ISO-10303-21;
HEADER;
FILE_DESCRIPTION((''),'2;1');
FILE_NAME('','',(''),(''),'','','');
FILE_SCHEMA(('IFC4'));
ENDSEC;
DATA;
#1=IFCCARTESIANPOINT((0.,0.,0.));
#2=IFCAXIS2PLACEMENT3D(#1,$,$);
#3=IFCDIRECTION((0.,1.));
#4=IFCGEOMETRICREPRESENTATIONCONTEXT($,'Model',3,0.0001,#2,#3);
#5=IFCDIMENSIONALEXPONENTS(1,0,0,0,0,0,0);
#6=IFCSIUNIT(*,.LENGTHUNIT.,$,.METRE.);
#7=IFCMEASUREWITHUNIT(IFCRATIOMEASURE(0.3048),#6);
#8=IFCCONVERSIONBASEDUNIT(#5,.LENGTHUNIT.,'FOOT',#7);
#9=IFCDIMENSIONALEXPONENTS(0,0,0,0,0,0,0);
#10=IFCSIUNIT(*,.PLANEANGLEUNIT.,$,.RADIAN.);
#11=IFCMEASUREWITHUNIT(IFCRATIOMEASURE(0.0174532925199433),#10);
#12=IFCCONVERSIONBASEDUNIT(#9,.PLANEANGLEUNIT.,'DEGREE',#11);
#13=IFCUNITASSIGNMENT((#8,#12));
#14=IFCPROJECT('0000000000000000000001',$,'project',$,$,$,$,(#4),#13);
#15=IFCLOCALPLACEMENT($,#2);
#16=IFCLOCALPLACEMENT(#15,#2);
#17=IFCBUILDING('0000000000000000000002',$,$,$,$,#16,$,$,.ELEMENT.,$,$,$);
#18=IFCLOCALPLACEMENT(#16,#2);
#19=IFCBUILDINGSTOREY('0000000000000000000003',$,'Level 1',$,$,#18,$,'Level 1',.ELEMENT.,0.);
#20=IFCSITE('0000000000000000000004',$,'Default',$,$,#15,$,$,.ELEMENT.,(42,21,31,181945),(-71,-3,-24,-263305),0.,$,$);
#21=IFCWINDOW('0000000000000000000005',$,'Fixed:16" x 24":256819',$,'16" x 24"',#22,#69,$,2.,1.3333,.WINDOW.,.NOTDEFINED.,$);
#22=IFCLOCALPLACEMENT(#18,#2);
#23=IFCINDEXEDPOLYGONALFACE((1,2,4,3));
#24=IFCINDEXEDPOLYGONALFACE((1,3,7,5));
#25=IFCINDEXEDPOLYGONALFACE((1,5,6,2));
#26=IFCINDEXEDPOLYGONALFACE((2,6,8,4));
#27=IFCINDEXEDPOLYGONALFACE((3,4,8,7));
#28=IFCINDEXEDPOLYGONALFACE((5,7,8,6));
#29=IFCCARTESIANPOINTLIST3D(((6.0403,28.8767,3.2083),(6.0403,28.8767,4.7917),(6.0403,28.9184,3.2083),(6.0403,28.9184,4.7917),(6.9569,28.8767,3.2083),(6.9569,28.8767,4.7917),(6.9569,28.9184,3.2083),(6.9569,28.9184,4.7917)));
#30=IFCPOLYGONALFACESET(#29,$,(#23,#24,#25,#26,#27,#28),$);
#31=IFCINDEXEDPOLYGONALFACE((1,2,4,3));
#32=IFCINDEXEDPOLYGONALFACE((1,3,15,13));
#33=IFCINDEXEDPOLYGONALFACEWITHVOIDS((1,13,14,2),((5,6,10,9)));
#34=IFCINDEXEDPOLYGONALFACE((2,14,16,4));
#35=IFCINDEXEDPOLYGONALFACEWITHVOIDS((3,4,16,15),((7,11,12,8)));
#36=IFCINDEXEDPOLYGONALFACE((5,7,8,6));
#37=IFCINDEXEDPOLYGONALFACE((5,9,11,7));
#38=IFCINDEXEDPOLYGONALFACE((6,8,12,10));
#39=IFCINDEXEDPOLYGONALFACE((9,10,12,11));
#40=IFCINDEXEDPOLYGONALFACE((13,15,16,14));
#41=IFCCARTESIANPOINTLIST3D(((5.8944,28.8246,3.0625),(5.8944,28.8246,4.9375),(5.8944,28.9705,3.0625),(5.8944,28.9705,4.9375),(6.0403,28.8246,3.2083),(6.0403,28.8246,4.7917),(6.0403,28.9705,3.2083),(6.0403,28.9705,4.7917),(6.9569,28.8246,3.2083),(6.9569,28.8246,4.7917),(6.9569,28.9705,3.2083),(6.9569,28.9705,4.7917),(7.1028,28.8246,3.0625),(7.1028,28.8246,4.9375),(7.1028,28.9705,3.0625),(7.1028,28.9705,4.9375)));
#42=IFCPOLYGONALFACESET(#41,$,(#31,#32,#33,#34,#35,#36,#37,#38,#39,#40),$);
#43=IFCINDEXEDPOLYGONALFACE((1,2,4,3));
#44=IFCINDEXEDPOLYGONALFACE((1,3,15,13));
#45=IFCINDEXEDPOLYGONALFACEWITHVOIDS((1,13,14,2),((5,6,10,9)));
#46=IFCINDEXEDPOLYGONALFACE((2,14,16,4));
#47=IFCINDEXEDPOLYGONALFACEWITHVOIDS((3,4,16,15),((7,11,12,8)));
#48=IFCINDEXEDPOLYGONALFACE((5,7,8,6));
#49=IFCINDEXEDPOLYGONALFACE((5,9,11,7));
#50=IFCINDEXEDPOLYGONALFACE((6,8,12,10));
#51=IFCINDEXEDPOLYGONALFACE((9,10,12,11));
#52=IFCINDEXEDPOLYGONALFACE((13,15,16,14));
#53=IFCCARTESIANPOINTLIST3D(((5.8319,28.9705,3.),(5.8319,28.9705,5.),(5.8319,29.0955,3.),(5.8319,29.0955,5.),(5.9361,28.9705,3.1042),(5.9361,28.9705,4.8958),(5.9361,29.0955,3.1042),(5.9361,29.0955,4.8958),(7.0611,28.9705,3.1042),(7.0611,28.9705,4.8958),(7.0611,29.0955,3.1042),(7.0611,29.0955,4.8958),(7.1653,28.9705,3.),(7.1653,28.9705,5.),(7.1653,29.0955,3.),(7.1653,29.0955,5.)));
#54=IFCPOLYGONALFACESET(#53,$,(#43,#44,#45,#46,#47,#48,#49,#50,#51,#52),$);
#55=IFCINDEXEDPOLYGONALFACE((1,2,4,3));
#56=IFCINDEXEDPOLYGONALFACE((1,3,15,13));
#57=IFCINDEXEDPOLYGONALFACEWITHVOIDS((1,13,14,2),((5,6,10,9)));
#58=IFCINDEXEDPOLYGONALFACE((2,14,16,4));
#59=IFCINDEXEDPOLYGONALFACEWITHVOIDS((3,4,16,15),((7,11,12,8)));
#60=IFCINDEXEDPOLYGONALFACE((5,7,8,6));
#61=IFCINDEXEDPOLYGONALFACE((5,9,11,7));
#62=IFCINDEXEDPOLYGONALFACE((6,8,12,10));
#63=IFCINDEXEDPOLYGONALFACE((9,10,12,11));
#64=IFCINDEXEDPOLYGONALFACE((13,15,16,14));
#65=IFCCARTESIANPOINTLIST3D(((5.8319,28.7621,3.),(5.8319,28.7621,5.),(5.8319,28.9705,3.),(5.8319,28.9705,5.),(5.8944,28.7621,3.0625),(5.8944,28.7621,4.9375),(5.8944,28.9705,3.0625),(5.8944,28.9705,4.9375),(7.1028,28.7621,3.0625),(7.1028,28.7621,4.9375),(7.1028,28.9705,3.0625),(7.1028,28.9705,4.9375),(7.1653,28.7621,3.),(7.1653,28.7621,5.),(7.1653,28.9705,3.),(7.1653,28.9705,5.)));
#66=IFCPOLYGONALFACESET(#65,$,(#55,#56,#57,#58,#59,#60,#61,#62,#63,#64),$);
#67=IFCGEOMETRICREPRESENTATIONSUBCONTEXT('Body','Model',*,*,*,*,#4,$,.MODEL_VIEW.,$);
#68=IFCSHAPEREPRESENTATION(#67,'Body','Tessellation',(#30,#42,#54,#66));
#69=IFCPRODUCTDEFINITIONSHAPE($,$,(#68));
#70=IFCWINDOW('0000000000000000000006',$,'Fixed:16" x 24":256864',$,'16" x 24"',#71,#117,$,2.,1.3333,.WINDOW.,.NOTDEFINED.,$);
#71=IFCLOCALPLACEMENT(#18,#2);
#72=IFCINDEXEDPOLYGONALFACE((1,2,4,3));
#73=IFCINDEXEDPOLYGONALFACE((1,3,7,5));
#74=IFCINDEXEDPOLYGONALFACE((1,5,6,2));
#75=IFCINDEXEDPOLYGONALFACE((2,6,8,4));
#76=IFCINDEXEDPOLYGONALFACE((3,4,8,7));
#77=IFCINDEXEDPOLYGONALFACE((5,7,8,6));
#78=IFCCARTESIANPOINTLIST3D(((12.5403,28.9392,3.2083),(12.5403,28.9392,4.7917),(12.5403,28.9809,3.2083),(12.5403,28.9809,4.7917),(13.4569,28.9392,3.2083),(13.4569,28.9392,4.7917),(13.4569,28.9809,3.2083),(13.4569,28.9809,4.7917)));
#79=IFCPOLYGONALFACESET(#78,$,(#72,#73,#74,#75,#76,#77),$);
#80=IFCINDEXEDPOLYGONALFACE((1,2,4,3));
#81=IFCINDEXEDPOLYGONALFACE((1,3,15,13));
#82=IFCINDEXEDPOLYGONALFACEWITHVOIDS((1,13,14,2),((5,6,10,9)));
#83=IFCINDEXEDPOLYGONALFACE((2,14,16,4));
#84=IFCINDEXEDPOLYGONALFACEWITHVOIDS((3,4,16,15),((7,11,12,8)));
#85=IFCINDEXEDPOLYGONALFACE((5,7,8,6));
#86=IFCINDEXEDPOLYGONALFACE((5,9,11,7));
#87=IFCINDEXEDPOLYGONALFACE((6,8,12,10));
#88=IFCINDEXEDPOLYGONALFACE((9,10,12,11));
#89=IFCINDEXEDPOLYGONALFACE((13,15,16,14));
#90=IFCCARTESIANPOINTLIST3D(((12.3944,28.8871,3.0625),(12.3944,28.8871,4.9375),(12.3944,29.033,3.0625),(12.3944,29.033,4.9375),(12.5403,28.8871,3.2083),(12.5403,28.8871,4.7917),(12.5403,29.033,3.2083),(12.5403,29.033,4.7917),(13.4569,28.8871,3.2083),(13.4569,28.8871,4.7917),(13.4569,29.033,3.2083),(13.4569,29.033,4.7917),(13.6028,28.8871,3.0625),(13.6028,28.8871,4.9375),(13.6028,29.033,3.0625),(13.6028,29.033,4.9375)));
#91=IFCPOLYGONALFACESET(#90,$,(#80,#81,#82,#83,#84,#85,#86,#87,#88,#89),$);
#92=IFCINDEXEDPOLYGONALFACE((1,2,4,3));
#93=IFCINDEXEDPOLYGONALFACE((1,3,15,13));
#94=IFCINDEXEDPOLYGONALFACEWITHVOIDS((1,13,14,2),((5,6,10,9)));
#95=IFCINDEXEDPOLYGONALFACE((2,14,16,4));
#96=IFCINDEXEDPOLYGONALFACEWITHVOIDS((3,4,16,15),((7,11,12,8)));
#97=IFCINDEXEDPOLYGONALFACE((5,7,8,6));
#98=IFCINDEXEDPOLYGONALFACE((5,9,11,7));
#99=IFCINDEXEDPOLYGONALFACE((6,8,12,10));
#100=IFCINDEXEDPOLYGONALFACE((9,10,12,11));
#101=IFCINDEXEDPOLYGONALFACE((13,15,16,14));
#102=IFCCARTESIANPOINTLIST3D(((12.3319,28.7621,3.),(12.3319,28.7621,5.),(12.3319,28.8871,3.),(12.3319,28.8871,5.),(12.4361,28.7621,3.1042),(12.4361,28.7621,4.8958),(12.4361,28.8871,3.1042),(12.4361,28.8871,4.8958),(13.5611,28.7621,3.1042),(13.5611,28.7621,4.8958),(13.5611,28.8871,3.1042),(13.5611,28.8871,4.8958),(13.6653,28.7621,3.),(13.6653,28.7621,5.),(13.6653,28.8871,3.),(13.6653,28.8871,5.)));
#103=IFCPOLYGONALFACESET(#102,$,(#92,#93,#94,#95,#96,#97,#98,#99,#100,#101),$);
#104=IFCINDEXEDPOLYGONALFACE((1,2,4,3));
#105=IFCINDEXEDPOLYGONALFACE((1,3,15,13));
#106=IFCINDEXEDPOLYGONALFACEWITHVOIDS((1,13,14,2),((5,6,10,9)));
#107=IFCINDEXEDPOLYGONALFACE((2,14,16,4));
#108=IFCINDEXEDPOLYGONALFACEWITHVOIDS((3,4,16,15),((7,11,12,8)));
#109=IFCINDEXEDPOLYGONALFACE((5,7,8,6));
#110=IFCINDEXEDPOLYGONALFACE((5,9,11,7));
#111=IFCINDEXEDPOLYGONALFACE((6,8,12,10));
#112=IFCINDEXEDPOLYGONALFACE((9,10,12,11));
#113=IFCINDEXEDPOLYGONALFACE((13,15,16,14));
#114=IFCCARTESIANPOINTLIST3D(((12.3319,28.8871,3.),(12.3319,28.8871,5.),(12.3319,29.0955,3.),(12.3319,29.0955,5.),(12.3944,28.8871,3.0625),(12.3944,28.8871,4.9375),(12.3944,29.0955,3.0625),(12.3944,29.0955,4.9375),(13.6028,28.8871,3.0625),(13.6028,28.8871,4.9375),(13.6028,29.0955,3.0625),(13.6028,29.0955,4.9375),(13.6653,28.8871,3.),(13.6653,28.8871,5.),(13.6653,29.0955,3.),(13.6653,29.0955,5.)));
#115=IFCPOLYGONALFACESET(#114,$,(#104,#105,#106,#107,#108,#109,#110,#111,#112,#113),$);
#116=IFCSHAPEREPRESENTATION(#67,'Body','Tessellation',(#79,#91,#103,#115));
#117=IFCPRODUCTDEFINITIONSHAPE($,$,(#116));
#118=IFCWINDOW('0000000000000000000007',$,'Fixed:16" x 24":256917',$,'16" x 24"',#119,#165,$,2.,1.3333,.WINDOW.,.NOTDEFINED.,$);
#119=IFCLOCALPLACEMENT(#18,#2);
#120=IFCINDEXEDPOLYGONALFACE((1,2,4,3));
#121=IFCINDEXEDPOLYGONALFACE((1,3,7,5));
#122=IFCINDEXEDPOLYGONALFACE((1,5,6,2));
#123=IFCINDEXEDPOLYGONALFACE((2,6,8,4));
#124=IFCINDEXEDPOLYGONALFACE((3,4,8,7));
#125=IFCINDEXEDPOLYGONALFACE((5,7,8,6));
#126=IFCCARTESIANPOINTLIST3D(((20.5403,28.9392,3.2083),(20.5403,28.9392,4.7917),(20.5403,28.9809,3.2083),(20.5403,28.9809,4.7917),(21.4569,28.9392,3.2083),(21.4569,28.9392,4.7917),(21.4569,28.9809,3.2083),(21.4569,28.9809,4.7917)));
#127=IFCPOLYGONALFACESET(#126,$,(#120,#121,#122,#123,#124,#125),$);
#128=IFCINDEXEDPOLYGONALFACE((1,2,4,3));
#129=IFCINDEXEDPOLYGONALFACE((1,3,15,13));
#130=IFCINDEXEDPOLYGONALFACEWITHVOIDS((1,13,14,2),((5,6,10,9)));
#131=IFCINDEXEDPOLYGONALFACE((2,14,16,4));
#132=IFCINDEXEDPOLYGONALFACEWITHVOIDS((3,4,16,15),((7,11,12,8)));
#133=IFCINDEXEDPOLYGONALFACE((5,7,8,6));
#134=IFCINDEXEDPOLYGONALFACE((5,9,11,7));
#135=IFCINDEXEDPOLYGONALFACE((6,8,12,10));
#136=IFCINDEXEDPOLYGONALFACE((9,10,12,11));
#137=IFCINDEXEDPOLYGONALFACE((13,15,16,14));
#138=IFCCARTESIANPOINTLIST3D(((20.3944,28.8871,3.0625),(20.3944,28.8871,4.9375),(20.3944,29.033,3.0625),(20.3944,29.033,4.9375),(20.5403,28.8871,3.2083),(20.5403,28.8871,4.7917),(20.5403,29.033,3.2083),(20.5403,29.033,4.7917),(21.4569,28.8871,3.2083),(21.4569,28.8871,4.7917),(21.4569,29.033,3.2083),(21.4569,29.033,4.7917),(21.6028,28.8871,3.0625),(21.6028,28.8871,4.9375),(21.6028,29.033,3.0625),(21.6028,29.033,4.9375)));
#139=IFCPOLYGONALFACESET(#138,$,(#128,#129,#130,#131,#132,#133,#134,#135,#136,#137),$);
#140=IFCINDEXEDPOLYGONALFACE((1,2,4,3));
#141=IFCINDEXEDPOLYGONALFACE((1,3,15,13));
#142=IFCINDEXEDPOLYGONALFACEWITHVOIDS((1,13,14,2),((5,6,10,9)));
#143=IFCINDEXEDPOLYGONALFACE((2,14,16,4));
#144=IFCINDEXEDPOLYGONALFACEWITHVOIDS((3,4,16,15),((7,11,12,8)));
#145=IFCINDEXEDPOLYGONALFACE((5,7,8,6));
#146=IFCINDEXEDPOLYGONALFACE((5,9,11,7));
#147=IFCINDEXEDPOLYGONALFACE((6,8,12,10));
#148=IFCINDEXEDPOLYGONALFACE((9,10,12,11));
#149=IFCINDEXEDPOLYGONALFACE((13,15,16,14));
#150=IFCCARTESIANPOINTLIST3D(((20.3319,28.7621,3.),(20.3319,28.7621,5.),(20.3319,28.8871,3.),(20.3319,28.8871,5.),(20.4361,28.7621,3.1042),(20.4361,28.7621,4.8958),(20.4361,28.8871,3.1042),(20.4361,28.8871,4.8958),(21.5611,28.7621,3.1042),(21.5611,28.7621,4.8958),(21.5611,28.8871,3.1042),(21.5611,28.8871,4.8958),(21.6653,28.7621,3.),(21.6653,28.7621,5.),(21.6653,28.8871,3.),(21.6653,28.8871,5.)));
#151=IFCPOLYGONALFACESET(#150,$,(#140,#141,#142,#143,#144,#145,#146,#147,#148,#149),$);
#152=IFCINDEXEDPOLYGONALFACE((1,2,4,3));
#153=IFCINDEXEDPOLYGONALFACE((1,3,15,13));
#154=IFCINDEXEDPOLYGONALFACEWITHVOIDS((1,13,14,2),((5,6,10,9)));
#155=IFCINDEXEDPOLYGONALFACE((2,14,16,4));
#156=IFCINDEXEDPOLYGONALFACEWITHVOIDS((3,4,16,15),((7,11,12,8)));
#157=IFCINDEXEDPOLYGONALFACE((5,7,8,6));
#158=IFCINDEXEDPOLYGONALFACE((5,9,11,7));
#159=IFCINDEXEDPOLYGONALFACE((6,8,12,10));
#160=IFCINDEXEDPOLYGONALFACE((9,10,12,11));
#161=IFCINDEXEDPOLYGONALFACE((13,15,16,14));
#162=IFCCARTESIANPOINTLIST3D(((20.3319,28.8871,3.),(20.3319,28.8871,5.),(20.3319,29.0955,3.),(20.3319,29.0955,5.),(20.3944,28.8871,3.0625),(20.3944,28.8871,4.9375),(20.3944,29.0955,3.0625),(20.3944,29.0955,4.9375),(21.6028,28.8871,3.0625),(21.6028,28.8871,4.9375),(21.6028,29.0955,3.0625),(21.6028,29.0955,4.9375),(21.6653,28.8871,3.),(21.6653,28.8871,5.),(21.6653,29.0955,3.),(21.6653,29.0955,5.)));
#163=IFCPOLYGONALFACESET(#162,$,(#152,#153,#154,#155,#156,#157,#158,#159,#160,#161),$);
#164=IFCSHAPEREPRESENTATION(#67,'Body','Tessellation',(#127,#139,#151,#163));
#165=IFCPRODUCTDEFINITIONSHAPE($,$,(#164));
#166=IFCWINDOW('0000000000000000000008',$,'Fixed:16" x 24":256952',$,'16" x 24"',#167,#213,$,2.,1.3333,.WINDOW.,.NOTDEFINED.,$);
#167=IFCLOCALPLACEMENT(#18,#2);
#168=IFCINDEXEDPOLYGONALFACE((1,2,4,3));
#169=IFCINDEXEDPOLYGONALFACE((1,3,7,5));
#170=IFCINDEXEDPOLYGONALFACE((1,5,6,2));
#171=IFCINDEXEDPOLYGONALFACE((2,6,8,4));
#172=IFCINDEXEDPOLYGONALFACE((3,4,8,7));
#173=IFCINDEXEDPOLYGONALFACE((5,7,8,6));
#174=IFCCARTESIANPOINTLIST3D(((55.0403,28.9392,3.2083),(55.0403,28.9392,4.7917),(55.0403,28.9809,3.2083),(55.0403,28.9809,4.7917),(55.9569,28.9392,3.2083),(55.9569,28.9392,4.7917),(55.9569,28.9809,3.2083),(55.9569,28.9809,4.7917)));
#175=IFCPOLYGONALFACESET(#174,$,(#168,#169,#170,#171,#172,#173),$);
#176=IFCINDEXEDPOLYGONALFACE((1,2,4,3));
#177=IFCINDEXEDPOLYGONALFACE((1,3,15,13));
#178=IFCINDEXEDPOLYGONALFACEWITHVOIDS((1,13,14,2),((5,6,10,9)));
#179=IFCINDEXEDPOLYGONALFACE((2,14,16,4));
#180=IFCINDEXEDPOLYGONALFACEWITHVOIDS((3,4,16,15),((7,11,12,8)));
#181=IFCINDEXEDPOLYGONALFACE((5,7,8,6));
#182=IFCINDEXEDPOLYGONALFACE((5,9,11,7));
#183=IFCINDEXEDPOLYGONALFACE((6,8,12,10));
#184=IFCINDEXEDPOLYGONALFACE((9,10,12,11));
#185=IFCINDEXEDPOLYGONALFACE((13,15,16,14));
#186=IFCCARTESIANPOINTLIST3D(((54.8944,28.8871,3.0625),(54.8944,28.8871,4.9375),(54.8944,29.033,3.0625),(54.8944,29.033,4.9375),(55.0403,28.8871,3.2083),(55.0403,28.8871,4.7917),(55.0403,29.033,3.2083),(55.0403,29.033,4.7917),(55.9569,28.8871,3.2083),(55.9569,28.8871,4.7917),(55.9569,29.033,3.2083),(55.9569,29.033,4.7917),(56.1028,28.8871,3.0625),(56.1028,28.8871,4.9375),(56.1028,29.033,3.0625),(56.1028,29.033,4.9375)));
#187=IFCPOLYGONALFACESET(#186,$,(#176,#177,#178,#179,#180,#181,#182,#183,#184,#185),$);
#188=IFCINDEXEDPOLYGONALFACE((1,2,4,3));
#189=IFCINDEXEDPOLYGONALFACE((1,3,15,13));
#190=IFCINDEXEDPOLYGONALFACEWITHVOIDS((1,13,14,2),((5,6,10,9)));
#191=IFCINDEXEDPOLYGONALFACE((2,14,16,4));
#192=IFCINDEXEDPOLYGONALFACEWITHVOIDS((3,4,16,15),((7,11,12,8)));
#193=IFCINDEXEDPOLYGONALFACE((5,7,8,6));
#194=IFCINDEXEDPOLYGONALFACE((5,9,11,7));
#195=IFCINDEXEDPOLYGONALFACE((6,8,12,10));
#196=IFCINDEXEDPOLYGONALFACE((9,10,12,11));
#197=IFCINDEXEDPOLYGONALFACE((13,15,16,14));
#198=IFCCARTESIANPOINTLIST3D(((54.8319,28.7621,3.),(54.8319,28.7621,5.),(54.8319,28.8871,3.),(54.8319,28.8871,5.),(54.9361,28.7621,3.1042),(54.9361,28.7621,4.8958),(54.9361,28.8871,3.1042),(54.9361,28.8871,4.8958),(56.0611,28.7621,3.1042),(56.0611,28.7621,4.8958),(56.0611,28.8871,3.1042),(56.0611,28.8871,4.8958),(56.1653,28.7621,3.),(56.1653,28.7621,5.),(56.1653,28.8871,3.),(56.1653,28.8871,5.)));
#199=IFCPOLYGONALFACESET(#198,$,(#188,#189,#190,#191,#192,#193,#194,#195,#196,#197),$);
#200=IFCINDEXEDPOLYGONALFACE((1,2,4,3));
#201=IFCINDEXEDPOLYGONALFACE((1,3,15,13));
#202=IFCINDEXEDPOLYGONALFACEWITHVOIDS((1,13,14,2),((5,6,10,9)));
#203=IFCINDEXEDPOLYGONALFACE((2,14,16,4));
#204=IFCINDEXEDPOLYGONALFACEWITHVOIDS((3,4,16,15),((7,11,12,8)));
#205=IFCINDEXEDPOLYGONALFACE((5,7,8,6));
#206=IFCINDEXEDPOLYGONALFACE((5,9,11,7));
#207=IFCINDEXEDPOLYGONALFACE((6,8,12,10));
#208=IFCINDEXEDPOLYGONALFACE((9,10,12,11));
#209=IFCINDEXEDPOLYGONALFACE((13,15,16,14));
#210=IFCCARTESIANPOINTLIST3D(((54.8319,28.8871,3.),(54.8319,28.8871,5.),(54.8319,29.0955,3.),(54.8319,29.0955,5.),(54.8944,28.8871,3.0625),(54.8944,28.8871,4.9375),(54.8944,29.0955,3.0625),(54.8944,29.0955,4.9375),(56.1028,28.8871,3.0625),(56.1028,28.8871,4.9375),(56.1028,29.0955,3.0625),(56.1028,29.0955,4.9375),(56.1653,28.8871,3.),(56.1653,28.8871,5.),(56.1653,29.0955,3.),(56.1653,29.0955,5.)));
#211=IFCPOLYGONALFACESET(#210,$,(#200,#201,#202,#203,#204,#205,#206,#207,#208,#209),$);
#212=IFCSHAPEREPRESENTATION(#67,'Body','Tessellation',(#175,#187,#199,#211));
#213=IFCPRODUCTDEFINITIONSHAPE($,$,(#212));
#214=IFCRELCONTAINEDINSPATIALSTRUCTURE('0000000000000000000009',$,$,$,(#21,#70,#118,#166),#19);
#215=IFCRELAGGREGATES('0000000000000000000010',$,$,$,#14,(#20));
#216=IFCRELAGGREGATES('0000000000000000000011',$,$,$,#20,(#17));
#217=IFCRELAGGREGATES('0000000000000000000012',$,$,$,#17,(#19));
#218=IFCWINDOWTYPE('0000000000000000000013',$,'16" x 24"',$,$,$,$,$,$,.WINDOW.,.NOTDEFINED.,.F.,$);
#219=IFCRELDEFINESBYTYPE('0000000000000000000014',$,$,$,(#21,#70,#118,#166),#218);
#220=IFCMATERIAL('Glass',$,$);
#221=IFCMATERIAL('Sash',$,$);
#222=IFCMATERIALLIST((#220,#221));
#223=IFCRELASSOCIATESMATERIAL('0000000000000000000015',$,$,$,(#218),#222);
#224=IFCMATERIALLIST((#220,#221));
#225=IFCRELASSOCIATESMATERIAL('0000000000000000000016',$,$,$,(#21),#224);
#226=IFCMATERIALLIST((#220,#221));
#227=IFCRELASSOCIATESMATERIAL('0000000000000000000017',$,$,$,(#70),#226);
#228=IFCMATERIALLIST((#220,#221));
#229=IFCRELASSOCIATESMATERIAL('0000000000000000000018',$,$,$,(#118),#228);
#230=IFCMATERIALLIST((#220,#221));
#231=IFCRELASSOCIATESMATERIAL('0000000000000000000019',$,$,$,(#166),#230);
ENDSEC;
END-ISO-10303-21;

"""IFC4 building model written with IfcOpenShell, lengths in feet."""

from ifc_helpers import new_model, entity, si_unit, converted_unit, direction, frame, origin, origin_2d_with_axis, place, context, subcontext, project, spatial, polyline, rectangle, outline, extrude, source, transform, mapped, material, material_list, type_object, type_shapes, element, save


model = new_model("IFC4")

# Units and contexts
model_context = context("Model", 3, precision=0.0001, world=origin(), true_north=direction((0.0, 1.0)))
body_context = subcontext(model_context, "Body", "Model", "MODEL_VIEW")
ifc_project = project(units=[converted_unit("LENGTHUNIT", "FOOT", entity("IfcRatioMeasure", 0.3048), si_unit("LENGTHUNIT", "METRE"), dimensions=[1, 0, 0, 0, 0, 0, 0]), converted_unit("PLANEANGLEUNIT", "DEGREE", entity("IfcRatioMeasure", 0.0174532925199433), si_unit("PLANEANGLEUNIT", "RADIAN"), dimensions=[0, 0, 0, 0, 0, 0, 0])], contexts=[model_context])

# Site, building, storey
site_placement = place(None, origin())
site = spatial("IfcSite", under=ifc_project, at=site_placement, Name="Default", CompositionType="ELEMENT", RefLatitude=(42, 21, 31, 181945), RefLongitude=(-71, -3, -24, -263305), RefElevation=0.0)
building_placement = place(site_placement, origin())
building = spatial("IfcBuilding", under=site, at=building_placement, CompositionType="ELEMENT")
storey_placement = place(building_placement, origin())
storey = spatial("IfcBuildingStorey", under=building, at=storey_placement, Name="Level 1", LongName="Level 1", CompositionType="ELEMENT", Elevation=0.0)

# Windows
ifc_material_1 = material(Name="Glass")
ifc_material_2 = material(Name="Sash")
ifc_material_list_1 = material_list([ifc_material_1, ifc_material_2])
ifc_material_list_2 = material_list([ifc_material_1, ifc_material_2])
window_type = type_object("IfcWindowType", Name="16\" x 24\"", ParameterTakesPrecedence=False, PartitioningType="NOTDEFINED", PredefinedType="WINDOW", material=ifc_material_list_2)
shared_shape_1 = source(origin(), body_context, "Body", "SweptSolid", [
    extrude(rectangle(XDim=0.0417, YDim=0.9167, at=origin_2d_with_axis()), frame((0.6667, 0.1979, 0.2083), z_axis=(0.0, 0.0, 1.0), x_axis=(0.0, 1.0, 0.0)), (0.0, 0.0, 1.0), 1.5833),
    extrude(outline(polyline([(-0.6042, -0.9375), (0.6042, -0.9375), (0.6042, 0.9375), (-0.6042, 0.9375), (-0.6042, -0.9375)]), holes=[polyline([(-0.4583, -0.7917), (-0.4583, 0.7917), (0.4583, 0.7917), (0.4583, -0.7917), (-0.4583, -0.7917)])]), frame((0.6667, 0.125, 1.0), z_axis=(0.0, 1.0, 0.0), x_axis=(1.0, 0.0, 0.0)), (0.0, 0.0, 1.0), 0.1458),
    extrude(outline(polyline([(-0.6667, -1.0), (0.6667, -1.0), (0.6667, 1.0), (-0.6667, 1.0), (-0.6667, -1.0)]), holes=[polyline([(-0.5625, -0.8958), (-0.5625, 0.8958), (0.5625, 0.8958), (0.5625, -0.8958), (-0.5625, -0.8958)])]), frame((0.6667, 0.0, 1.0), z_axis=(0.0, 1.0, 0.0), x_axis=(1.0, 0.0, 0.0)), (0.0, 0.0, 1.0), 0.125),
    extrude(outline(polyline([(-1.0, -0.6667), (1.0, -0.6667), (1.0, 0.6667), (-1.0, 0.6667), (-1.0, -0.6667)]), holes=[polyline([(-0.9375, -0.6042), (-0.9375, 0.6042), (0.9375, 0.6042), (0.9375, -0.6042), (-0.9375, -0.6042)])]), frame((0.6667, 0.125, 1.0), z_axis=(0.0, 1.0, 0.0), x_axis=(0.0, 0.0, -1.0)), (0.0, 0.0, 1.0), 0.2083),
])
type_shapes(window_type, [shared_shape_1])
placement_1 = place(storey_placement, frame((-0.1681, 28.9288, 0.0)))
placement_2 = place(placement_1, frame((7.3333, 0.1667, 3.0)))
window_1_placement = place(placement_2, frame((0.0, 0.0, 0.0), z_axis=(0.0, 0.0, 1.0), x_axis=(-1.0, 0.0, 0.0)))
element("IfcWindow", 1, at=window_1_placement, inside=storey, type_object=window_type, material=ifc_material_list_1, Name="Fixed:16\" x 24\":256819", ObjectType="16\" x 24\"", OverallHeight=2.0, OverallWidth=1.3333, PartitioningType="NOTDEFINED", PredefinedType="WINDOW", context=body_context, shape_type="MappedRepresentation", body=[
    mapped(shared_shape_1, transform((0.0, 0.0, 0.0), scale=1.0)),
])
ifc_material_list_3 = material_list([ifc_material_1, ifc_material_2])
placement_3 = place(placement_1, frame((12.5, -0.1667, 3.0)))
window_2_placement = place(placement_3, origin())
element("IfcWindow", 2, at=window_2_placement, inside=storey, type_object=window_type, material=ifc_material_list_3, Name="Fixed:16\" x 24\":256864", ObjectType="16\" x 24\"", OverallHeight=2.0, OverallWidth=1.3333, PartitioningType="NOTDEFINED", PredefinedType="WINDOW", context=body_context, shape_type="MappedRepresentation", body=[
    mapped(shared_shape_1, transform((0.0, 0.0, 0.0), scale=1.0)),
])
ifc_material_list_4 = material_list([ifc_material_1, ifc_material_2])
placement_4 = place(placement_1, frame((20.5, -0.1667, 3.0)))
window_3_placement = place(placement_4, origin())
element("IfcWindow", 3, at=window_3_placement, inside=storey, type_object=window_type, material=ifc_material_list_4, Name="Fixed:16\" x 24\":256917", ObjectType="16\" x 24\"", OverallHeight=2.0, OverallWidth=1.3333, PartitioningType="NOTDEFINED", PredefinedType="WINDOW", context=body_context, shape_type="MappedRepresentation", body=[
    mapped(shared_shape_1, transform((0.0, 0.0, 0.0), scale=1.0)),
])
ifc_material_list_5 = material_list([ifc_material_1, ifc_material_2])
placement_5 = place(placement_1, frame((55.0, -0.1667, 3.0)))
window_4_placement = place(placement_5, origin())
element("IfcWindow", 4, at=window_4_placement, inside=storey, type_object=window_type, material=ifc_material_list_5, Name="Fixed:16\" x 24\":256952", ObjectType="16\" x 24\"", OverallHeight=2.0, OverallWidth=1.3333, PartitioningType="NOTDEFINED", PredefinedType="WINDOW", context=body_context, shape_type="MappedRepresentation", body=[
    mapped(shared_shape_1, transform((0.0, 0.0, 0.0), scale=1.0)),
])

save(model, "model.ifc")
